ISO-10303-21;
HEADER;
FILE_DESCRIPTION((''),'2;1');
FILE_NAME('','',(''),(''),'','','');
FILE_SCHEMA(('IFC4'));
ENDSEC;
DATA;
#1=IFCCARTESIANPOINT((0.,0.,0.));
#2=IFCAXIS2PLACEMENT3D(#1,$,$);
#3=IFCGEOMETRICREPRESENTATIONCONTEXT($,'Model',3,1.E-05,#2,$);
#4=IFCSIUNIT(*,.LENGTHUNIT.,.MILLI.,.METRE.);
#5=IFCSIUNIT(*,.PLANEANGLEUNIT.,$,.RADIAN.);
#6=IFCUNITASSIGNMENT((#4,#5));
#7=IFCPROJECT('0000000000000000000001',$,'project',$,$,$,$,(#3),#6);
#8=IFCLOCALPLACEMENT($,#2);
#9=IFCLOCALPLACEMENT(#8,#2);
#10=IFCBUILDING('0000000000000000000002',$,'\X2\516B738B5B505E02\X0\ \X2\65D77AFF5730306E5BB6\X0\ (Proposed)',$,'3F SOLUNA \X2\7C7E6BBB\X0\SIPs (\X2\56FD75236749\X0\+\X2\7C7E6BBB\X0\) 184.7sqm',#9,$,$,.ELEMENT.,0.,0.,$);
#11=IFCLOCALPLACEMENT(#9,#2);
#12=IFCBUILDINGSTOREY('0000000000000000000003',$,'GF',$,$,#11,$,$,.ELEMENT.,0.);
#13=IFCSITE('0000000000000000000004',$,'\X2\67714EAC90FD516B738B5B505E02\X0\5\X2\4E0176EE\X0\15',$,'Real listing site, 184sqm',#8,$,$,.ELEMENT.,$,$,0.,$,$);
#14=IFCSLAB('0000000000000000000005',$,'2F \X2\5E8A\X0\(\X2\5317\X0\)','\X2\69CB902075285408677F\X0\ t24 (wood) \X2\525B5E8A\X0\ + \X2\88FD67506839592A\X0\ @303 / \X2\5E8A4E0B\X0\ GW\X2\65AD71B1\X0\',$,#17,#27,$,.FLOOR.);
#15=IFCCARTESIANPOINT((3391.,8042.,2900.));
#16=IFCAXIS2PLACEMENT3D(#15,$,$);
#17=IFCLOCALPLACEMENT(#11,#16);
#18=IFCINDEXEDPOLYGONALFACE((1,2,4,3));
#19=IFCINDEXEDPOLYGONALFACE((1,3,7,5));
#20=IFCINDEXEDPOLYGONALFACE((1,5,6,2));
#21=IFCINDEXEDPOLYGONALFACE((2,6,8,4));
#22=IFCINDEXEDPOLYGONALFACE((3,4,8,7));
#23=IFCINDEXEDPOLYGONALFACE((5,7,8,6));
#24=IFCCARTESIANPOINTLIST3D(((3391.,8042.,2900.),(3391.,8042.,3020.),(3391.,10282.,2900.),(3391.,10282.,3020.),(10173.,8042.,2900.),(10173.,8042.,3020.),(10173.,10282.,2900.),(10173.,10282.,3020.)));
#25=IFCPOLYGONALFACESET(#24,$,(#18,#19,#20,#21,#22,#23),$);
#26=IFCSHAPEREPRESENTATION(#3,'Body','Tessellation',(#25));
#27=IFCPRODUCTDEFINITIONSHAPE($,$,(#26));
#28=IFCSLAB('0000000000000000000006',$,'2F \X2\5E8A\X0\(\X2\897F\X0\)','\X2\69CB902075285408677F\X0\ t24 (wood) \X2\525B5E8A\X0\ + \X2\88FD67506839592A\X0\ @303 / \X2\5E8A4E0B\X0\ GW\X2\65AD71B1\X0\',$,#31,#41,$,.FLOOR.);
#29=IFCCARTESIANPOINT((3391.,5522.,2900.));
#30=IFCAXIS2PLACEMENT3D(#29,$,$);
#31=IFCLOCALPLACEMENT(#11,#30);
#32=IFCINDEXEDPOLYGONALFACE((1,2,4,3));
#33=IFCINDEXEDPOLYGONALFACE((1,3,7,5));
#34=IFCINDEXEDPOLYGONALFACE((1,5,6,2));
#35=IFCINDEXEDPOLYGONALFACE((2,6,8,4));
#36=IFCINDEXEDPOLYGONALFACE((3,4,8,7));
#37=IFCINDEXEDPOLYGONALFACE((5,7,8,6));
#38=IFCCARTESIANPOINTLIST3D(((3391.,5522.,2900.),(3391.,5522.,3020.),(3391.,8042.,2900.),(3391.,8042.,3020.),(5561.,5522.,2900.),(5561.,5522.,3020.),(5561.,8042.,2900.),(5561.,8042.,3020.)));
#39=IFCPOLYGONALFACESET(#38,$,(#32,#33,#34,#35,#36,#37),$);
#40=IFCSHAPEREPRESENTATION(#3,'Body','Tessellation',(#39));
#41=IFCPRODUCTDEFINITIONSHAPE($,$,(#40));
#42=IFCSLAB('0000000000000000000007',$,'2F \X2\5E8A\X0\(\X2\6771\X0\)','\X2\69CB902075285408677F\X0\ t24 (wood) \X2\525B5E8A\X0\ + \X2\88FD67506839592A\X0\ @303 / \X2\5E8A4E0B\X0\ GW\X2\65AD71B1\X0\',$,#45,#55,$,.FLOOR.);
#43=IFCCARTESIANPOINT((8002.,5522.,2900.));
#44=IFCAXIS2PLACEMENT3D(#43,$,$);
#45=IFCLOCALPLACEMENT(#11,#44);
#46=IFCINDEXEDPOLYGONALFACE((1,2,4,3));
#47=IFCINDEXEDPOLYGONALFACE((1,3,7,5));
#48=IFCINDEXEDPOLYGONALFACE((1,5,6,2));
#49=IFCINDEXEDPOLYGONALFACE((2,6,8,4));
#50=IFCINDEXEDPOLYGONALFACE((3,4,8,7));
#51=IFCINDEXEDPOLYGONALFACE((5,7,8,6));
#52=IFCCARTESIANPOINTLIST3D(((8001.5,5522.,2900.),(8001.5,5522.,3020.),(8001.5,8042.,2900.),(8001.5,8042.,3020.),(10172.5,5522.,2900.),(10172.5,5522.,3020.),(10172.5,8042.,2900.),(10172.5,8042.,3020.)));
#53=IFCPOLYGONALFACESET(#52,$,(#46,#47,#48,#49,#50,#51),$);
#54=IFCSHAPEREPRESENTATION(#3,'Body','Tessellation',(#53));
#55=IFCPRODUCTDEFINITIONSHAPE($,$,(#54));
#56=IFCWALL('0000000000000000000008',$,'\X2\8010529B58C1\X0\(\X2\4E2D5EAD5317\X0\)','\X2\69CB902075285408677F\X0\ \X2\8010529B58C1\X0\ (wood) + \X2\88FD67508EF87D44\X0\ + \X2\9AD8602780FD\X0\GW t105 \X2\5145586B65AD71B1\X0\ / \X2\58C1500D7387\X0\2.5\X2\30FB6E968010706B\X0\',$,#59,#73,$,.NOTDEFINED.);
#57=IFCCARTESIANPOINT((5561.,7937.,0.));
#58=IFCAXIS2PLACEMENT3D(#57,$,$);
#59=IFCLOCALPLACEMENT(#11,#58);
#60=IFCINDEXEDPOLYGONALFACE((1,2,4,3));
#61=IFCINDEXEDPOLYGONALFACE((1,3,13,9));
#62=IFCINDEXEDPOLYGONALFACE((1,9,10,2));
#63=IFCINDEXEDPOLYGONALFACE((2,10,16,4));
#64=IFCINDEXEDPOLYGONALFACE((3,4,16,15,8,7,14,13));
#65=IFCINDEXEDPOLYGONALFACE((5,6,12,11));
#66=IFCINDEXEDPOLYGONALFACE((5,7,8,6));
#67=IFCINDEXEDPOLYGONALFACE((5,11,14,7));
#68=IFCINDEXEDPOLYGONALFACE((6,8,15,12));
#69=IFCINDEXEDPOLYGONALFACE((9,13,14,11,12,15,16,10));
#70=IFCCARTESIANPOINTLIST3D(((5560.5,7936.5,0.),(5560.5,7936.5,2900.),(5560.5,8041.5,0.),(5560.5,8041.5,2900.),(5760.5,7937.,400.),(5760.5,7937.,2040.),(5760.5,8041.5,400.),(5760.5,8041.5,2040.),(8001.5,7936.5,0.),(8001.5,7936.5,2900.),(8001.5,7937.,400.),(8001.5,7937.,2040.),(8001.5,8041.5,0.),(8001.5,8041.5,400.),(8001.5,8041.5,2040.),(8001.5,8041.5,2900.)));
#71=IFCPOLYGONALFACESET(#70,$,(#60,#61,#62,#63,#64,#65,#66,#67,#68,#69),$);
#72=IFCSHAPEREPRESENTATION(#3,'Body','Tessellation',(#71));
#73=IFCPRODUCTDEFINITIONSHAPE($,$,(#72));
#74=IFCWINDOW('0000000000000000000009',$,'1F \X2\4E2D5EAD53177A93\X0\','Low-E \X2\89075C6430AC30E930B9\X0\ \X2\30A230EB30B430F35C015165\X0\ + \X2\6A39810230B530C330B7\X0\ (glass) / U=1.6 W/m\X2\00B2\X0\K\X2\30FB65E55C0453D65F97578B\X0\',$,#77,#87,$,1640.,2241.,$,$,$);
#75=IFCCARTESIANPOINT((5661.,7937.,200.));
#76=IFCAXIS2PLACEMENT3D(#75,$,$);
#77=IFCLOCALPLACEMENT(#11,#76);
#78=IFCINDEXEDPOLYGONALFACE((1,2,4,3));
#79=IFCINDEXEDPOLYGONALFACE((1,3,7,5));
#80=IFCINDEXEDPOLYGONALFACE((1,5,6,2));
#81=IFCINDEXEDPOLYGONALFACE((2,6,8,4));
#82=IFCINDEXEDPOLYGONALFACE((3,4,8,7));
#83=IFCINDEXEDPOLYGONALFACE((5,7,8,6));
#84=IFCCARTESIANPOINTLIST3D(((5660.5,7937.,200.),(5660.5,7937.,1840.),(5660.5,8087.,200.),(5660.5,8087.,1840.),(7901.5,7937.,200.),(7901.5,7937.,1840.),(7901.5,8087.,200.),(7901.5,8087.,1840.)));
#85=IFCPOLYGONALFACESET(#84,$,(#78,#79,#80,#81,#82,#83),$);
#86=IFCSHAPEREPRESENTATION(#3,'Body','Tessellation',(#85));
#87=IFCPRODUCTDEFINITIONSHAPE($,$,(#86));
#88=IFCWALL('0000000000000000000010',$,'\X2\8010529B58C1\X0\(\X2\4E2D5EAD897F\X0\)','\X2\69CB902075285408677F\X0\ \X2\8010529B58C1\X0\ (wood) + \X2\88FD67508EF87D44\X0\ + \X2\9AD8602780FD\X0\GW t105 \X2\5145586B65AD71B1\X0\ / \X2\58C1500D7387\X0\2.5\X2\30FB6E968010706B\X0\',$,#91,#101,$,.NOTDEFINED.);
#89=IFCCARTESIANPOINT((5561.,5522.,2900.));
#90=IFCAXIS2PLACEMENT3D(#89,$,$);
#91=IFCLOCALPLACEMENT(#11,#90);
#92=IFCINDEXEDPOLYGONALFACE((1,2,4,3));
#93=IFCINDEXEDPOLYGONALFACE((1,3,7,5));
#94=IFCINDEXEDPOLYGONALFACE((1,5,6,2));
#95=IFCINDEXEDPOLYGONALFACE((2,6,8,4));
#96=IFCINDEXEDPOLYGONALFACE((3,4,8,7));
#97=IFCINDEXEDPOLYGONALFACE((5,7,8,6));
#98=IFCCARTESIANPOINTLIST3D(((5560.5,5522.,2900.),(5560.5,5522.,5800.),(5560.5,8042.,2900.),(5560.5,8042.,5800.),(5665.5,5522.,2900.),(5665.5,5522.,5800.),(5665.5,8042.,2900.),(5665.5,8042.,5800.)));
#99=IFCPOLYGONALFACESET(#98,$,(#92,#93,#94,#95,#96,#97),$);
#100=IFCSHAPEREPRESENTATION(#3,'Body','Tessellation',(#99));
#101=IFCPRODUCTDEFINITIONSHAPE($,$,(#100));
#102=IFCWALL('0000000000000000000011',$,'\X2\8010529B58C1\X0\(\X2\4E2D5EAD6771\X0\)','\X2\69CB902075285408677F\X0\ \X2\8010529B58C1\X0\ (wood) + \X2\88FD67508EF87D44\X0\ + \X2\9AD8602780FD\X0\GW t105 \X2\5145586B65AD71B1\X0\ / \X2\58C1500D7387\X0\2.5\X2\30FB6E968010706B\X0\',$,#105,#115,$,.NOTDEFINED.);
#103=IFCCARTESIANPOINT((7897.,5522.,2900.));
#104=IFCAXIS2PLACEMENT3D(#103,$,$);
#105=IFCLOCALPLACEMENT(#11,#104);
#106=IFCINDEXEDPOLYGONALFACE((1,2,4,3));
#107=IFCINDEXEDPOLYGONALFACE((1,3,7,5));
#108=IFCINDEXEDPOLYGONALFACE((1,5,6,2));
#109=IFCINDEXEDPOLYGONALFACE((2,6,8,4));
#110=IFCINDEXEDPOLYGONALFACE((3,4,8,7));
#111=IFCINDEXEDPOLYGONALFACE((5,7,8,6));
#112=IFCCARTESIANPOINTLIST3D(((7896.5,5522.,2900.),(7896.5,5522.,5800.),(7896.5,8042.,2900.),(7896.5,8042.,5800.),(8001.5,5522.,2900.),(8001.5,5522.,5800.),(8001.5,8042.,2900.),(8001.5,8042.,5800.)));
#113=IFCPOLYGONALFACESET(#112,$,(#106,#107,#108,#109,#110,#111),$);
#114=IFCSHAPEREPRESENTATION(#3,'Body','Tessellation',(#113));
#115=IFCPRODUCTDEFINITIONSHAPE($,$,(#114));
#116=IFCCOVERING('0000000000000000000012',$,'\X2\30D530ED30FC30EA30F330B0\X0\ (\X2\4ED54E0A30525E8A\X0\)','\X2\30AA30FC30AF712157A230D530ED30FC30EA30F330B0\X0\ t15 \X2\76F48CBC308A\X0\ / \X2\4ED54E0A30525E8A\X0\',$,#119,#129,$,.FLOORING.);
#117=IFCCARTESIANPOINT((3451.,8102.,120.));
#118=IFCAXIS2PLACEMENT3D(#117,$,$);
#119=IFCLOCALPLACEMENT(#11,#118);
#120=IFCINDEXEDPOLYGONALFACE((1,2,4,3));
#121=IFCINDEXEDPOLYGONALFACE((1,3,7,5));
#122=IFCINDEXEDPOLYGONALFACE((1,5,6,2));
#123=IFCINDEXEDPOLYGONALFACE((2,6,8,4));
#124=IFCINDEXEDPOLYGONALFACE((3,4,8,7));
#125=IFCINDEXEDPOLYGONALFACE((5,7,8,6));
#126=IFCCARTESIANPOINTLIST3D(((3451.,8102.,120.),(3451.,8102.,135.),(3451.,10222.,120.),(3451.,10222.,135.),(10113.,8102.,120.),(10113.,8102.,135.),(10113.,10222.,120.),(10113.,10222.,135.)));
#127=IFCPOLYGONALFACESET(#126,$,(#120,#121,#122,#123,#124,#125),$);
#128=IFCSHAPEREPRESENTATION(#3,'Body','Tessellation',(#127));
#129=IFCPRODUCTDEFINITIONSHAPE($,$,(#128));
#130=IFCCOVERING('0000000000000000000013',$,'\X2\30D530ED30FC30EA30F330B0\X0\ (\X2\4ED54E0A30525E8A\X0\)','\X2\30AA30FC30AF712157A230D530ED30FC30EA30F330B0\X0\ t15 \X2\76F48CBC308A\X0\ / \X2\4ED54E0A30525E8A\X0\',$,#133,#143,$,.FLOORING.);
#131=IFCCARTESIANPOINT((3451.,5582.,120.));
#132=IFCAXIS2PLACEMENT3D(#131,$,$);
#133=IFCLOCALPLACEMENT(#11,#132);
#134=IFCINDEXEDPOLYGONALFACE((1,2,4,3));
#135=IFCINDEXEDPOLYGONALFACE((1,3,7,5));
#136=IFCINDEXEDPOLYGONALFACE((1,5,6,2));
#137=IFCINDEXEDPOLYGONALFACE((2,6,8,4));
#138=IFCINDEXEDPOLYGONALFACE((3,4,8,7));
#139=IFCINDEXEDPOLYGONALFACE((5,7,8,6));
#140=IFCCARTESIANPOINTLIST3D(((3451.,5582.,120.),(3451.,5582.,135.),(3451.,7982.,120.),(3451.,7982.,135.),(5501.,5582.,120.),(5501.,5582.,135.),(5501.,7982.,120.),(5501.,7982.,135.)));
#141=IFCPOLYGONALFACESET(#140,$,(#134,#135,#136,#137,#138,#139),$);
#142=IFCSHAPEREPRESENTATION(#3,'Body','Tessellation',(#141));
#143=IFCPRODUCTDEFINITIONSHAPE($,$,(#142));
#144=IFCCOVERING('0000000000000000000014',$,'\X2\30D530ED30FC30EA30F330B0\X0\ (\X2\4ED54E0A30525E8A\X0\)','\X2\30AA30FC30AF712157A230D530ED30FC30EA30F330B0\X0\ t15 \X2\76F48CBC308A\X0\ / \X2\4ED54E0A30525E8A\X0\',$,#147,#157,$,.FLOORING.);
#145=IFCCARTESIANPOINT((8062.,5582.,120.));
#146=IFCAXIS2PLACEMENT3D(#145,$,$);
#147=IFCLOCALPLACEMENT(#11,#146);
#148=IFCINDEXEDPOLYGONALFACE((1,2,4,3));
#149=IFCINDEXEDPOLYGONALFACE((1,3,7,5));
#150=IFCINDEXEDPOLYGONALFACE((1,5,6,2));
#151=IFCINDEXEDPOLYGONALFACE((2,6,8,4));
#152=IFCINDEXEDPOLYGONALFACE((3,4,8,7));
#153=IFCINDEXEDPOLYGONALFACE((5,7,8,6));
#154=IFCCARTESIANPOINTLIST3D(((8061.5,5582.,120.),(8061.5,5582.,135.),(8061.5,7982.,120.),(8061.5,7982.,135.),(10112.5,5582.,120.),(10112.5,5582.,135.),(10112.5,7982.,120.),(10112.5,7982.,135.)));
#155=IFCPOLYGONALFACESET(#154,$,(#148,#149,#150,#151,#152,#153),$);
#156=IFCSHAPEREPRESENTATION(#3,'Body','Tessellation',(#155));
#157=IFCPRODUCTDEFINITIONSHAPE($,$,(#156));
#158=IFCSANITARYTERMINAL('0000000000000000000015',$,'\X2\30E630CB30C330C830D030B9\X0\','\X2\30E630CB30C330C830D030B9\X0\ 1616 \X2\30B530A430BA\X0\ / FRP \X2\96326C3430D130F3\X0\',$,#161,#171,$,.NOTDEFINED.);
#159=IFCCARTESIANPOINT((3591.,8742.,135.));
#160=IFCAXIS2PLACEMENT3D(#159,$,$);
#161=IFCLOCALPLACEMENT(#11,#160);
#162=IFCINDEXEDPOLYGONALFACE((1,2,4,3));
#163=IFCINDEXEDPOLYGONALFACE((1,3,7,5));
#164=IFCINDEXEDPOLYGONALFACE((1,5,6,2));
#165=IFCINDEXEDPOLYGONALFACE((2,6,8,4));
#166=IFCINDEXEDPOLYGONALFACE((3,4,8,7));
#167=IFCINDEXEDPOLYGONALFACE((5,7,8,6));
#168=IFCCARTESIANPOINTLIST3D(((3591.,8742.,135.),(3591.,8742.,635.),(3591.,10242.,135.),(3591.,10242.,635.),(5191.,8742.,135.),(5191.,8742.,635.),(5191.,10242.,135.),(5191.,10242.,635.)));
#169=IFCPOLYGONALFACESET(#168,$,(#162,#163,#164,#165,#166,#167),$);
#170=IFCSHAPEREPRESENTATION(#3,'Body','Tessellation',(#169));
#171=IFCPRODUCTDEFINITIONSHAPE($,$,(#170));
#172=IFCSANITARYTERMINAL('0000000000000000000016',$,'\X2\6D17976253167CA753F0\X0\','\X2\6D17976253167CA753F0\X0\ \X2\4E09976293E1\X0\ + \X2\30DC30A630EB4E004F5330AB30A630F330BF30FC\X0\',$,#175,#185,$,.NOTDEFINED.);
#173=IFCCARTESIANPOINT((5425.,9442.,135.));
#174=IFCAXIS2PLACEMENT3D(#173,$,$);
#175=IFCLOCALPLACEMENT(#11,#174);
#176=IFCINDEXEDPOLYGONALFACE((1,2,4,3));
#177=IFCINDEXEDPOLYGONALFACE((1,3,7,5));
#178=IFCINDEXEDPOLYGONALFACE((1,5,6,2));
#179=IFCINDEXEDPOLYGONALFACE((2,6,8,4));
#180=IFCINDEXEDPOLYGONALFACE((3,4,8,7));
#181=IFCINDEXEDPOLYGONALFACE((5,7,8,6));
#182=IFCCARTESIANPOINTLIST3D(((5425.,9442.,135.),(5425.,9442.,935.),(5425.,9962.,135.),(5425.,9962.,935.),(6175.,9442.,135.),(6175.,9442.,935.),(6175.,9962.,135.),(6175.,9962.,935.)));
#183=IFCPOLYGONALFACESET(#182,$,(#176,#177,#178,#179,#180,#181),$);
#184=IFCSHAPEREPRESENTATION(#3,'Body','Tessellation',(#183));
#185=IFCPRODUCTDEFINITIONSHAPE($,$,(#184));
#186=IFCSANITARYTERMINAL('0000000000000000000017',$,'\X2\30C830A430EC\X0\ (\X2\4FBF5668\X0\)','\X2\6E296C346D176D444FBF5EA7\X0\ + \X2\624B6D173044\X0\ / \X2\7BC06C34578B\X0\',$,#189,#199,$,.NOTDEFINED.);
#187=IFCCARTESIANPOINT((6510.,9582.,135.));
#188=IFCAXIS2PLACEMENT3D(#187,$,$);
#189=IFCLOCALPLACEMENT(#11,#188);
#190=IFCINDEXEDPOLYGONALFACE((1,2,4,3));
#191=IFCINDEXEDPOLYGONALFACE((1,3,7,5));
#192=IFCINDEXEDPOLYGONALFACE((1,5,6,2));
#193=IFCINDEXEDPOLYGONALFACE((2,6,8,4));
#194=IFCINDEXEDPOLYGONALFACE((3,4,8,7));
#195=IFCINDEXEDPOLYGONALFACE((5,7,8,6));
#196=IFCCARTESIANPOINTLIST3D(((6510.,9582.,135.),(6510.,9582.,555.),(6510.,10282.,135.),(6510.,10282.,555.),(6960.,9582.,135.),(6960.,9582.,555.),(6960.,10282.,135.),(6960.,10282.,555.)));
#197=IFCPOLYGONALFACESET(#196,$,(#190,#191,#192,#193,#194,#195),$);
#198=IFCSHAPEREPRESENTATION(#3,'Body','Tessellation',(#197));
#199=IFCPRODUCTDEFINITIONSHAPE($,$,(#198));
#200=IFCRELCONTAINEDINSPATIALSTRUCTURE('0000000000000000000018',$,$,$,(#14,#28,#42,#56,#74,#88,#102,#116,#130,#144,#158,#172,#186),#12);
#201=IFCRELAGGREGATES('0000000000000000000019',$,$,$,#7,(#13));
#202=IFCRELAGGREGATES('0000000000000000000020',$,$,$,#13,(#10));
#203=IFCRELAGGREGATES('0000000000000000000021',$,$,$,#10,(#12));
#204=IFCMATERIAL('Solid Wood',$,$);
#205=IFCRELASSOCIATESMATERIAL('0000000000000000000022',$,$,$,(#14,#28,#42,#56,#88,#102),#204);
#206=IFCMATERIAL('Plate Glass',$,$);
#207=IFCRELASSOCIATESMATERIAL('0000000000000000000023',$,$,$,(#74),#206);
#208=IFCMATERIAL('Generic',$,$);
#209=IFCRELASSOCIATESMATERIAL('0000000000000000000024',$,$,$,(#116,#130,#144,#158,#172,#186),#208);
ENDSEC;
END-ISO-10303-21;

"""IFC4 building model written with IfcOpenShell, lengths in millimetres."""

from ifc_helpers import new_model, si_unit, frame, frame_2d, origin, place, context, project, spatial, rectangle, extrude, material, element, fill, save


model = new_model("IFC4")

# Units and contexts
model_context = context("Model", 3, precision=1e-05, world=origin())
ifc_project = project(units=[si_unit("LENGTHUNIT", "METRE", prefix="MILLI"), si_unit("PLANEANGLEUNIT", "RADIAN")], contexts=[model_context])

# Site, building, storey
site_placement = place(None, origin())
site = spatial("IfcSite", under=ifc_project, at=site_placement, Name="東京都八王子市5丁目15", ObjectType="Real listing site, 184sqm", CompositionType="ELEMENT", RefElevation=0.0)
building_placement = place(site_placement, origin())
building = spatial("IfcBuilding", under=site, at=building_placement, Name="八王子市 旗竿地の家 (Proposed)", ObjectType="3F SOLUNA 籾殻SIPs (国産杉+籾殻) 184.7sqm", CompositionType="ELEMENT", ElevationOfRefHeight=0.0, ElevationOfTerrain=0.0)
storey_placement = place(building_placement, origin())
storey = spatial("IfcBuildingStorey", under=building, at=storey_placement, Name="GF", CompositionType="ELEMENT", Elevation=0.0)

# Slabs
ifc_material_1 = material(Name="Solid Wood")
slab_1_placement = place(storey_placement, frame((3391.0, 8042.0, 2900.0)))
element("IfcSlab", 1, at=slab_1_placement, inside=storey, material=ifc_material_1, Name="2F 床(北)", Description="構造用合板 t24 (wood) 剛床 + 製材根太 @303 / 床下 GW断熱", PredefinedType="FLOOR", context=model_context, shape_type="SweptSolid", body=[
    extrude(rectangle(XDim=6782.0, YDim=2240.0, at=frame_2d((3391.0, 1120.0))), frame((3391.0, 8042.0, 2900.0)), (0.0, 0.0, 1.0), 120.0),
])
slab_2_placement = place(storey_placement, frame((3391.0, 5522.0, 2900.0)))
element("IfcSlab", 2, at=slab_2_placement, inside=storey, material=ifc_material_1, Name="2F 床(西)", Description="構造用合板 t24 (wood) 剛床 + 製材根太 @303 / 床下 GW断熱", PredefinedType="FLOOR", context=model_context, shape_type="SweptSolid", body=[
    extrude(rectangle(XDim=2170.0, YDim=2520.0, at=frame_2d((1085.0, 1260.0))), frame((3391.0, 5522.0, 2900.0)), (0.0, 0.0, 1.0), 120.0),
])
slab_3_placement = place(storey_placement, frame((8002.0, 5522.0, 2900.0)))
element("IfcSlab", 3, at=slab_3_placement, inside=storey, material=ifc_material_1, Name="2F 床(東)", Description="構造用合板 t24 (wood) 剛床 + 製材根太 @303 / 床下 GW断熱", PredefinedType="FLOOR", context=model_context, shape_type="SweptSolid", body=[
    extrude(rectangle(XDim=2171.0, YDim=2520.0, at=frame_2d((1085.0, 1260.0))), frame((8002.0, 5522.0, 2900.0)), (0.0, 0.0, 1.0), 120.0),
])

# Wall, opening, window
wall_1_placement = place(storey_placement, frame((5561.0, 7937.0, 0.0)))
wall_1 = element("IfcWall", 4, at=wall_1_placement, inside=storey, material=ifc_material_1, Name="耐力壁(中庭北)", Description="構造用合板 耐力壁 (wood) + 製材軸組 + 高性能GW t105 充填断熱 / 壁倍率2.5・準耐火", PredefinedType="NOTDEFINED", context=model_context, shape_type="SweptSolid", body=[
    extrude(rectangle(XDim=2441.0, YDim=105.0, at=frame_2d((1220.0, 52.0))), frame((5561.0, 7937.0, 0.0)), (0.0, 0.0, 1.0), 2900.0),
])
opening_1_placement = place(storey_placement, frame((5661.0, 7937.0, 200.0)))
opening_1 = element("IfcOpeningElement", 5, at=opening_1_placement, cuts=wall_1, PredefinedType="NOTDEFINED", context=model_context, shape_type="SweptSolid", body=[
    extrude(rectangle(XDim=2241.0, YDim=150.0, at=frame_2d((1120.0, 75.0))), frame((5661.0, 7937.0, 200.0)), (0.0, 0.0, 1.0), 1640.0),
])
ifc_material_2 = material(Name="Plate Glass")
window_1_placement = place(storey_placement, frame((5661.0, 7937.0, 200.0)))
window_1 = element("IfcWindow", 6, at=window_1_placement, inside=storey, material=ifc_material_2, Name="1F 中庭北窓", Description="Low-E 複層ガラス アルゴン封入 + 樹脂サッシ (glass) / U=1.6 W/m²K・日射取得型", OverallHeight=1640.0, OverallWidth=2241.0, context=model_context, shape_type="SweptSolid", body=[
    extrude(rectangle(XDim=2241.0, YDim=150.0, at=frame_2d((1120.0, 75.0))), frame((5661.0, 7937.0, 200.0)), (0.0, 0.0, 1.0), 1640.0),
])
fill(opening_1, window_1)

# Walls
wall_2_placement = place(storey_placement, frame((5561.0, 5522.0, 2900.0)))
element("IfcWall", 7, at=wall_2_placement, inside=storey, material=ifc_material_1, Name="耐力壁(中庭西)", Description="構造用合板 耐力壁 (wood) + 製材軸組 + 高性能GW t105 充填断熱 / 壁倍率2.5・準耐火", PredefinedType="NOTDEFINED", context=model_context, shape_type="SweptSolid", body=[
    extrude(rectangle(XDim=105.0, YDim=2520.0, at=frame_2d((52.0, 1260.0))), frame((5561.0, 5522.0, 2900.0)), (0.0, 0.0, 1.0), 2900.0),
])
wall_3_placement = place(storey_placement, frame((7897.0, 5522.0, 2900.0)))
element("IfcWall", 8, at=wall_3_placement, inside=storey, material=ifc_material_1, Name="耐力壁(中庭東)", Description="構造用合板 耐力壁 (wood) + 製材軸組 + 高性能GW t105 充填断熱 / 壁倍率2.5・準耐火", PredefinedType="NOTDEFINED", context=model_context, shape_type="SweptSolid", body=[
    extrude(rectangle(XDim=105.0, YDim=2520.0, at=frame_2d((52.0, 1260.0))), frame((7897.0, 5522.0, 2900.0)), (0.0, 0.0, 1.0), 2900.0),
])

# Coverings
ifc_material_3 = material(Name="Generic")
covering_1_placement = place(storey_placement, frame((3451.0, 8102.0, 120.0)))
element("IfcCovering", 9, at=covering_1_placement, inside=storey, material=ifc_material_3, Name="フローリング (仕上げ床)", Description="オーク無垢フローリング t15 直貼り / 仕上げ床", PredefinedType="FLOORING", context=model_context, shape_type="SweptSolid", body=[
    extrude(rectangle(XDim=6662.0, YDim=2120.0, at=frame_2d((3331.0, 1060.0))), frame((3451.0, 8102.0, 120.0)), (0.0, 0.0, 1.0), 15.0),
])
covering_2_placement = place(storey_placement, frame((3451.0, 5582.0, 120.0)))
element("IfcCovering", 10, at=covering_2_placement, inside=storey, material=ifc_material_3, Name="フローリング (仕上げ床)", Description="オーク無垢フローリング t15 直貼り / 仕上げ床", PredefinedType="FLOORING", context=model_context, shape_type="SweptSolid", body=[
    extrude(rectangle(XDim=2050.0, YDim=2400.0, at=frame_2d((1025.0, 1200.0))), frame((3451.0, 5582.0, 120.0)), (0.0, 0.0, 1.0), 15.0),
])
covering_3_placement = place(storey_placement, frame((8062.0, 5582.0, 120.0)))
element("IfcCovering", 11, at=covering_3_placement, inside=storey, material=ifc_material_3, Name="フローリング (仕上げ床)", Description="オーク無垢フローリング t15 直貼り / 仕上げ床", PredefinedType="FLOORING", context=model_context, shape_type="SweptSolid", body=[
    extrude(rectangle(XDim=2051.0, YDim=2400.0, at=frame_2d((1025.0, 1200.0))), frame((8062.0, 5582.0, 120.0)), (0.0, 0.0, 1.0), 15.0),
])

# Sanitary terminals
sanitary_terminal_1_placement = place(storey_placement, frame((3591.0, 8742.0, 135.0)))
element("IfcSanitaryTerminal", 12, at=sanitary_terminal_1_placement, inside=storey, material=ifc_material_3, Name="ユニットバス", Description="ユニットバス 1616 サイズ / FRP 防水パン", PredefinedType="NOTDEFINED", context=model_context, shape_type="SweptSolid", body=[
    extrude(rectangle(XDim=1600.0, YDim=1500.0, at=frame_2d((800.0, 750.0))), frame((3591.0, 8742.0, 135.0)), (0.0, 0.0, 1.0), 500.0),
])
sanitary_terminal_2_placement = place(storey_placement, frame((5425.0, 9442.0, 135.0)))
element("IfcSanitaryTerminal", 13, at=sanitary_terminal_2_placement, inside=storey, material=ifc_material_3, Name="洗面化粧台", Description="洗面化粧台 三面鏡 + ボウル一体カウンター", PredefinedType="NOTDEFINED", context=model_context, shape_type="SweptSolid", body=[
    extrude(rectangle(XDim=750.0, YDim=520.0, at=frame_2d((375.0, 260.0))), frame((5425.0, 9442.0, 135.0)), (0.0, 0.0, 1.0), 800.0),
])
sanitary_terminal_3_placement = place(storey_placement, frame((6510.0, 9582.0, 135.0)))
element("IfcSanitaryTerminal", 14, at=sanitary_terminal_3_placement, inside=storey, material=ifc_material_3, Name="トイレ (便器)", Description="温水洗浄便座 + 手洗い / 節水型", PredefinedType="NOTDEFINED", context=model_context, shape_type="SweptSolid", body=[
    extrude(rectangle(XDim=450.0, YDim=700.0, at=frame_2d((225.0, 350.0))), frame((6510.0, 9582.0, 135.0)), (0.0, 0.0, 1.0), 420.0),
])

save(model, "model.ifc")
